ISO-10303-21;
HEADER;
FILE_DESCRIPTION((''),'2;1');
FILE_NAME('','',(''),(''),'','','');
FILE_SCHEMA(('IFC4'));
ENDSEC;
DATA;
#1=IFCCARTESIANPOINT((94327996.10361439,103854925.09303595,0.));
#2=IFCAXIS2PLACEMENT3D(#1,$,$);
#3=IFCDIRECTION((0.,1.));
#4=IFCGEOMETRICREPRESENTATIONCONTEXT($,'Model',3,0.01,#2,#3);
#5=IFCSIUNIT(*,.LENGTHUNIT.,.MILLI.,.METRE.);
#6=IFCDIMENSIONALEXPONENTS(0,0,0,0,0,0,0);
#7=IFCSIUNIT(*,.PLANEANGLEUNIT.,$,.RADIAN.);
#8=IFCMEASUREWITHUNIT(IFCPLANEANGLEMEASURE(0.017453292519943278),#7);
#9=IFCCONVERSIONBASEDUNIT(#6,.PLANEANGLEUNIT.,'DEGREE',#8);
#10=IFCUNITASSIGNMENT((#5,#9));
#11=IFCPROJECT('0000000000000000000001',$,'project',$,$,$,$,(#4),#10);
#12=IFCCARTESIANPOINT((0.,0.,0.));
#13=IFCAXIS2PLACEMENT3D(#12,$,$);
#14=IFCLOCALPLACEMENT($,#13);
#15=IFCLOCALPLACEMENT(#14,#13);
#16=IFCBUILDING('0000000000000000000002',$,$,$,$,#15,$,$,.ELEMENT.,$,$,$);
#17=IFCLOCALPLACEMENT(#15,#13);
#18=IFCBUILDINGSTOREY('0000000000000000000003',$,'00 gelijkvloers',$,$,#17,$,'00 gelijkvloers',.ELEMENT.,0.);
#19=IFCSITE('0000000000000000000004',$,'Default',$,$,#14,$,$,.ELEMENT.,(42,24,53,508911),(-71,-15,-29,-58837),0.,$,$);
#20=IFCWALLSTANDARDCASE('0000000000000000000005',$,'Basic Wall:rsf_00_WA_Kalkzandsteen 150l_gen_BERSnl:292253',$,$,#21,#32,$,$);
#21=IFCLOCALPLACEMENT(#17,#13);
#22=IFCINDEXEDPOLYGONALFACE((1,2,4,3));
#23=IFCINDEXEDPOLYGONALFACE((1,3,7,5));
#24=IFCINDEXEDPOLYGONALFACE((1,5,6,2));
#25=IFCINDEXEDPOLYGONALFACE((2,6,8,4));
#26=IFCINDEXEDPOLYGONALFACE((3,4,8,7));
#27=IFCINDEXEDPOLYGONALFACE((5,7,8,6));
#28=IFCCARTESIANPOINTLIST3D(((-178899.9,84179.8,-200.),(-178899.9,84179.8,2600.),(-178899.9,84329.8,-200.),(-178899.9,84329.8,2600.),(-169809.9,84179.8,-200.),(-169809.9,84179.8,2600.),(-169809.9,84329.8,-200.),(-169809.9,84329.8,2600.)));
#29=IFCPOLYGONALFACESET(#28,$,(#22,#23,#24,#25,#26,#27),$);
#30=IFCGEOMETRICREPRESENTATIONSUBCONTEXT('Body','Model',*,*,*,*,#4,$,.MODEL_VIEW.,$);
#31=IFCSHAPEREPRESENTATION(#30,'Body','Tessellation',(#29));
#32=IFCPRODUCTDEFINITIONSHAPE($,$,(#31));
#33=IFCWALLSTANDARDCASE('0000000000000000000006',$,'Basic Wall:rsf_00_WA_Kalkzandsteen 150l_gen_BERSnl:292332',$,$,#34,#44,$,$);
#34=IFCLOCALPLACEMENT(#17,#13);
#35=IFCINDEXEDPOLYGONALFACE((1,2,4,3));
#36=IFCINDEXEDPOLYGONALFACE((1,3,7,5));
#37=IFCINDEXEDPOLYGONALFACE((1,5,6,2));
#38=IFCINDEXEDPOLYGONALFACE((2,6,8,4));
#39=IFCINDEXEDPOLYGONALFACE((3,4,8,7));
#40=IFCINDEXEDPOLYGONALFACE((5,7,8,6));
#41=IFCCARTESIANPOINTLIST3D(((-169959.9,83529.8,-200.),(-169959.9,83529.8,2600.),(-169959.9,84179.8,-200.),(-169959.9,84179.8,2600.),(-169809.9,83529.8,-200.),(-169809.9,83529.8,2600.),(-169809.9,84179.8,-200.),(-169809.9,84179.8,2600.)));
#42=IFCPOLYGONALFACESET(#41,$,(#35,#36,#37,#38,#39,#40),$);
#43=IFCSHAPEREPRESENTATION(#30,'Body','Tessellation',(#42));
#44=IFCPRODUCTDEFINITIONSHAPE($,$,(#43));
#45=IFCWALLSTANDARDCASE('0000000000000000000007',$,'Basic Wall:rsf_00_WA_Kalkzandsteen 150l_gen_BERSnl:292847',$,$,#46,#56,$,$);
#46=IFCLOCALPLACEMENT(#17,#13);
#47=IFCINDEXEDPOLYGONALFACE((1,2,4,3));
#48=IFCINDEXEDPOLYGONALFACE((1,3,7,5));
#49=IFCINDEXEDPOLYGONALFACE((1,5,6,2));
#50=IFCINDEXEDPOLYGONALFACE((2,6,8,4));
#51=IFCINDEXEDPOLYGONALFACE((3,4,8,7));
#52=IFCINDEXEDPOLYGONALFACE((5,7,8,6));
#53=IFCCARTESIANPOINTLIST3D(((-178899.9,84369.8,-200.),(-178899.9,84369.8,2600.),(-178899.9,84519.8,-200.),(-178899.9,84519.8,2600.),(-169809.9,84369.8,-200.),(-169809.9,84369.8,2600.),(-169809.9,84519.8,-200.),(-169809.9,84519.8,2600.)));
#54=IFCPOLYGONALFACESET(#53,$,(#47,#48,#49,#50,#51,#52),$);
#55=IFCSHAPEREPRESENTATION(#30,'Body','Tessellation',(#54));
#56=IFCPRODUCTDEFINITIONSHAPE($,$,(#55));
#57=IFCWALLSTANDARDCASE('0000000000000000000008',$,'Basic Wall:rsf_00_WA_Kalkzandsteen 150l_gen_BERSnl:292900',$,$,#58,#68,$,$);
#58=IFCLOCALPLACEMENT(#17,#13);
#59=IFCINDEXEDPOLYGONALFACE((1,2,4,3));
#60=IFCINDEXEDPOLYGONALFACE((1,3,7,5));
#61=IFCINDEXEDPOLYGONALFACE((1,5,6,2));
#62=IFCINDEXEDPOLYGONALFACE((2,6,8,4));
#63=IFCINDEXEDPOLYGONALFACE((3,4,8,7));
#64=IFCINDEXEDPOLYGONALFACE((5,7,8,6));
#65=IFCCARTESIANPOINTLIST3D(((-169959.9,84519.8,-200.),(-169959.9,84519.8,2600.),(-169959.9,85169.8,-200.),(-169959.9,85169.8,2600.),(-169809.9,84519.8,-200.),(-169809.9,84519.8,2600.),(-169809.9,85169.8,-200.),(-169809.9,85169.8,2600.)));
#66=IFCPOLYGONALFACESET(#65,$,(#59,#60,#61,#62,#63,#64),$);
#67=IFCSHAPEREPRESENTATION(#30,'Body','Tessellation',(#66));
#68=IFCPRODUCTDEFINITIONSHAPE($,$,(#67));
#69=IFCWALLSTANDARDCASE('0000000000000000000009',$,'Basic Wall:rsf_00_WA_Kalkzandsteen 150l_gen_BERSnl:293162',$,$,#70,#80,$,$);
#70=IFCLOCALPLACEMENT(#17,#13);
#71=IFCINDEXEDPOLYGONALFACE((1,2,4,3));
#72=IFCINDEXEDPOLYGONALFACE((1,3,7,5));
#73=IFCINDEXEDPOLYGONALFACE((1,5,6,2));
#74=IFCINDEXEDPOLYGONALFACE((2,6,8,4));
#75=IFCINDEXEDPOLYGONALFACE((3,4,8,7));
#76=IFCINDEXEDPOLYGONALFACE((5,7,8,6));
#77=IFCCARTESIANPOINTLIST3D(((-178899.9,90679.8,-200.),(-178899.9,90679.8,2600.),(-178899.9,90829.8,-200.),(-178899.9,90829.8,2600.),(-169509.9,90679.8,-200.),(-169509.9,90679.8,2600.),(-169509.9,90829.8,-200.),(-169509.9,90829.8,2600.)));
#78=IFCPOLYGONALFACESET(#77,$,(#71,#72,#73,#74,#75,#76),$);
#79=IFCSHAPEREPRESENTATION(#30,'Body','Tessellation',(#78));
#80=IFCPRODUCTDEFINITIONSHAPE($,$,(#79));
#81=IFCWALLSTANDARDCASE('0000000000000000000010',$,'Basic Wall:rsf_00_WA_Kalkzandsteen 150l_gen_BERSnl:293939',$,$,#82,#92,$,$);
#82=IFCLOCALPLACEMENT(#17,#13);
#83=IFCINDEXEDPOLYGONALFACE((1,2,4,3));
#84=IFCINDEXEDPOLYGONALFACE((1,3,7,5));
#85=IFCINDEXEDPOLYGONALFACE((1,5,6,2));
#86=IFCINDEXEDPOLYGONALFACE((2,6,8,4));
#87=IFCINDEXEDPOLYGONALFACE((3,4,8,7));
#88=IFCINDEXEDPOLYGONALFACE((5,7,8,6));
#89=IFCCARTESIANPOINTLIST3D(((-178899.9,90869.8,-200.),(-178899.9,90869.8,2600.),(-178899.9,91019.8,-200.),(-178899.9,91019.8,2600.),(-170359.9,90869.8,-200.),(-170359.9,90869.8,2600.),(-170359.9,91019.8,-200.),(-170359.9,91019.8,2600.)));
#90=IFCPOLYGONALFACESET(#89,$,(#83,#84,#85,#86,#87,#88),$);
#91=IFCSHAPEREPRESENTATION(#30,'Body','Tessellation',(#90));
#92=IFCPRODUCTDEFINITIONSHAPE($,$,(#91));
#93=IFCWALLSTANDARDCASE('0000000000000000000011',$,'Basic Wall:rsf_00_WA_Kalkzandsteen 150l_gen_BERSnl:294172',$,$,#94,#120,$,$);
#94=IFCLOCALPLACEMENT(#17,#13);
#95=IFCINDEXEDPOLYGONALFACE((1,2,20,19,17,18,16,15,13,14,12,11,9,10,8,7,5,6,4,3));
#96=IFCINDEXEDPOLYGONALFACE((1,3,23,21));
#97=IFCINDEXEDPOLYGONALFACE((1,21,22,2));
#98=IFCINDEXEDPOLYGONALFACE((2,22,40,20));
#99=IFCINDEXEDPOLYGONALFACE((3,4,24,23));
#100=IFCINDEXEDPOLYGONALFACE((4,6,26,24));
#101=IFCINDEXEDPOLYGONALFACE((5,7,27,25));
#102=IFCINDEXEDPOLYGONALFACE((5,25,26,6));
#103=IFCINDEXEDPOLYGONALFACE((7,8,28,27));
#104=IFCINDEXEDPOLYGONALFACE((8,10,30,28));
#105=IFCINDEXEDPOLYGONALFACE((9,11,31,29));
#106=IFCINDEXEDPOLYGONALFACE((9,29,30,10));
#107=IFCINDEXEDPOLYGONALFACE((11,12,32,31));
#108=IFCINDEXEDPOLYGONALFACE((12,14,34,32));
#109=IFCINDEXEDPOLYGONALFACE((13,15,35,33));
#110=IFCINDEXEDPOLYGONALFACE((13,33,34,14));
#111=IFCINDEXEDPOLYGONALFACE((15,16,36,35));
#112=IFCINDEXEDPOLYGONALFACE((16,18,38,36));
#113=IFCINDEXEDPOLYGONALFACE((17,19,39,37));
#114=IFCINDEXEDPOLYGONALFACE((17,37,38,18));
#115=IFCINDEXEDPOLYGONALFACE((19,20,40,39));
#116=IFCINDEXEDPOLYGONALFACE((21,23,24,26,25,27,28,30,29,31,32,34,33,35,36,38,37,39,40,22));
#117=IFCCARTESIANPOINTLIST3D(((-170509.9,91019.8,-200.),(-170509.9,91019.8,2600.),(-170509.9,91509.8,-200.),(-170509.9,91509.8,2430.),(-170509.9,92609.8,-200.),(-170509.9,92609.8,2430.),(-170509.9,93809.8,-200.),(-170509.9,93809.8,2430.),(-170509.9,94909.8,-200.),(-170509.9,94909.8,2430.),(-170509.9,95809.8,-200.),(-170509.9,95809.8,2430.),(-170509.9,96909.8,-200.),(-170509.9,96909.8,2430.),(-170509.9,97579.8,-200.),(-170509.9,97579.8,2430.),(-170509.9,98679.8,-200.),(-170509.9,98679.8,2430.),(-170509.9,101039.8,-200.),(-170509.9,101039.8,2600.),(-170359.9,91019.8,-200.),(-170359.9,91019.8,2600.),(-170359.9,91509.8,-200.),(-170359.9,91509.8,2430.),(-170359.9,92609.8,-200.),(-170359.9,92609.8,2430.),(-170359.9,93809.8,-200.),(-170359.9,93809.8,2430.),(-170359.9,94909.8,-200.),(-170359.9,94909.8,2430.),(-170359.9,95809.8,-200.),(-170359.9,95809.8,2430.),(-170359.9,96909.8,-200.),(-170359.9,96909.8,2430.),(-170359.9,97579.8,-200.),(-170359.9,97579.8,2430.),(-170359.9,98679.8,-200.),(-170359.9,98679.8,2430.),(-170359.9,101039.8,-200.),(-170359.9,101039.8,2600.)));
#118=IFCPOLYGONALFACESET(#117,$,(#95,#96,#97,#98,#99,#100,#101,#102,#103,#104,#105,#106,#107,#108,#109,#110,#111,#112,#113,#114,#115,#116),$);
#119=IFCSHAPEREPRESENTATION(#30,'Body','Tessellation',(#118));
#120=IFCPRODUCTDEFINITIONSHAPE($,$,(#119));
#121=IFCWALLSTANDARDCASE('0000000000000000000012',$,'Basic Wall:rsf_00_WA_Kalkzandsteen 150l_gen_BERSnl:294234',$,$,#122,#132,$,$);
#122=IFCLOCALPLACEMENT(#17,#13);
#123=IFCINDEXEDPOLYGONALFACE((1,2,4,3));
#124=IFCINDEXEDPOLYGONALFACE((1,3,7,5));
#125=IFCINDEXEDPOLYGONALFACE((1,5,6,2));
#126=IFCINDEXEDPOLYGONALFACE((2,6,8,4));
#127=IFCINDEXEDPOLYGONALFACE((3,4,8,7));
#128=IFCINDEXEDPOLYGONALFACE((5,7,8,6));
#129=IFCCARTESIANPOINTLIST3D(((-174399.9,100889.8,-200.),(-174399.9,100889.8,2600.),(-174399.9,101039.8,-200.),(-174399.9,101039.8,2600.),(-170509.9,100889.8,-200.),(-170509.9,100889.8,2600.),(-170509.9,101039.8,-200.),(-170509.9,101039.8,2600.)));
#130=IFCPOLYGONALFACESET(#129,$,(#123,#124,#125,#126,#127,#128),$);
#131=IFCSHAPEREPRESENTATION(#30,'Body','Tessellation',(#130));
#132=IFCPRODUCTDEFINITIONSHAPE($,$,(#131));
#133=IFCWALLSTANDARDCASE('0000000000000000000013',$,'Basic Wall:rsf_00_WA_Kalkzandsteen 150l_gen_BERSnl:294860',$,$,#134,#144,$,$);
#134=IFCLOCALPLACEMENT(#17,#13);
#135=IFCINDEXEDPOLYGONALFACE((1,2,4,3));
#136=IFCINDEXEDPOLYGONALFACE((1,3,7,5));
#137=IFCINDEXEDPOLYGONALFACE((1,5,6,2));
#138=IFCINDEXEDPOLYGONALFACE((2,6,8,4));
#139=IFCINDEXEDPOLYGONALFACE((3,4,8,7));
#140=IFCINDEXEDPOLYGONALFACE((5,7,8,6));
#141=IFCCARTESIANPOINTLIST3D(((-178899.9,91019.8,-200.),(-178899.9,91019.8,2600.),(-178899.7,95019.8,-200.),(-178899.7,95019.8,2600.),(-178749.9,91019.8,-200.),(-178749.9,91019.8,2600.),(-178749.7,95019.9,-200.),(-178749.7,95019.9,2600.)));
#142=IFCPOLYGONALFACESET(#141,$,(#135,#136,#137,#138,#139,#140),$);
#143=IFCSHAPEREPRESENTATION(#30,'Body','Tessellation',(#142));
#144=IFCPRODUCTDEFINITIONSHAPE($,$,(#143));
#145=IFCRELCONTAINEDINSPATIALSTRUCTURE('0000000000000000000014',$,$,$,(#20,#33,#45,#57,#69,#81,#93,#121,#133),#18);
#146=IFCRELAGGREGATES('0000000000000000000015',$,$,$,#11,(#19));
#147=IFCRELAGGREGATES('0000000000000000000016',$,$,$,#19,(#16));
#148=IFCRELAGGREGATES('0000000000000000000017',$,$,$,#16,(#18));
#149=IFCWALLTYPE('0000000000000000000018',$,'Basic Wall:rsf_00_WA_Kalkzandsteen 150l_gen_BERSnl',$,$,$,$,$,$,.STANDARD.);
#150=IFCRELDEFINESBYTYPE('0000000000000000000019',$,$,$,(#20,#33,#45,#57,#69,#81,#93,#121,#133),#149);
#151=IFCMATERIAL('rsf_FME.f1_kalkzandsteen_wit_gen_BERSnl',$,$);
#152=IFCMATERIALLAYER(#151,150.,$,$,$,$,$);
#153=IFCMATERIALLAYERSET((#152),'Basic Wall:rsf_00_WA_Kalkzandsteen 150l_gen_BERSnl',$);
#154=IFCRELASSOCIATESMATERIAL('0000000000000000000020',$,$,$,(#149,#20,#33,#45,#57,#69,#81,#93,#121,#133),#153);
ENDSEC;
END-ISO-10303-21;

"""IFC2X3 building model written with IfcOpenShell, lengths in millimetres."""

from ifc_helpers import new_model, entity, si_unit, converted_unit, direction, frame, frame_2d, origin, origin_2d_with_axis, place, context, subcontext, project, spatial, polyline, rectangle, outline, extrude, clip, bounded_halfspace, material, layer, layer_set, layer_usage, type_object, element, save


model = new_model("IFC2X3")

# Units and contexts
model_context = context("Model", 3, precision=0.01, world=frame((94327996.10361439, 103854925.09303595, 0.0)), true_north=direction((0.0, 1.0)))
body_context = subcontext(model_context, "Body", "Model", "MODEL_VIEW")
ifc_project = project(units=[si_unit("LENGTHUNIT", "METRE", prefix="MILLI"), converted_unit("PLANEANGLEUNIT", "DEGREE", entity("IfcPlaneAngleMeasure", 0.017453292519943278), si_unit("PLANEANGLEUNIT", "RADIAN"), dimensions=[0, 0, 0, 0, 0, 0, 0])], contexts=[model_context])

# Site, building, storey
site_placement = place(None, origin())
site = spatial("IfcSite", under=ifc_project, at=site_placement, Name="Default", CompositionType="ELEMENT", RefLatitude=(42, 24, 53, 508911), RefLongitude=(-71, -15, -29, -58837), RefElevation=0.0)
building_placement = place(site_placement, origin())
building = spatial("IfcBuilding", under=site, at=building_placement, CompositionType="ELEMENT")
storey_placement = place(building_placement, origin())
storey = spatial("IfcBuildingStorey", under=building, at=storey_placement, Name="00 gelijkvloers", LongName="00 gelijkvloers", CompositionType="ELEMENT", Elevation=0.0)

# Walls
ifc_material = material(Name="rsf_FME.f1_kalkzandsteen_wit_gen_BERSnl")
ifc_layer = layer(ifc_material, 150.0)
ifc_layer_set = layer_set([ifc_layer], Name="Basic Wall:rsf_00_WA_Kalkzandsteen 150l_gen_BERSnl")
ifc_layer_usage_1 = layer_usage(ifc_layer_set, "AXIS2", "POSITIVE", -75.0)
wall_type = type_object("IfcWallType", Name="Basic Wall:rsf_00_WA_Kalkzandsteen 150l_gen_BERSnl", PredefinedType="STANDARD", material=ifc_layer_set)
wall_1_placement = place(storey_placement, frame((-178899.9, 84254.8, -200.0)))
element("IfcWallStandardCase", 1, at=wall_1_placement, inside=storey, type_object=wall_type, material=ifc_layer_usage_1, Name="Basic Wall:rsf_00_WA_Kalkzandsteen 150l_gen_BERSnl:292253", context=body_context, shape_type="Clipping", body=[
    clip(extrude(rectangle(XDim=9090.0, YDim=150.0, at=frame_2d((4545.0, 0.0), x_axis=(-1.0, 0.0))), origin(), (0.0, 0.0, 1.0), 2800.0), bounded_halfspace(frame((0.0, 75.0, 2800.0), z_axis=(0.0, 0.0, -1.0), x_axis=(0.0, 1.0, 0.0)), True, frame((0.0, 75.0, 2800.0)), polyline([(0.0, 0.0), (0.0, -150.0), (150.0, -150.0), (8940.0, -150.0), (9090.0, -150.0), (9090.0, 0.0), (0.0, 0.0)]))),
])
ifc_layer_usage_2 = layer_usage(ifc_layer_set, "AXIS2", "POSITIVE", -75.0)
wall_2_placement = place(storey_placement, frame((-169884.9, 84179.8, -200.0), z_axis=(0.0, 0.0, 1.0), x_axis=(0.0, -1.0, 0.0)))
element("IfcWallStandardCase", 2, at=wall_2_placement, inside=storey, type_object=wall_type, material=ifc_layer_usage_2, Name="Basic Wall:rsf_00_WA_Kalkzandsteen 150l_gen_BERSnl:292332", context=body_context, shape_type="Clipping", body=[
    clip(extrude(rectangle(XDim=650.0, YDim=150.0, at=frame_2d((325.0, 0.0), x_axis=(-1.0, 0.0))), origin(), (0.0, 0.0, 1.0), 2800.0), bounded_halfspace(frame((0.0, -75.0, 2800.0), z_axis=(0.0, 0.0, -1.0), x_axis=(-1.0, 0.0, 0.0)), True, frame((0.0, -75.0, 2800.0)), polyline([(0.0, 0.0), (650.0, 0.0), (650.0, 150.0), (500.0, 150.0), (0.0, 150.0), (0.0, 0.0)]))),
])
ifc_layer_usage_3 = layer_usage(ifc_layer_set, "AXIS2", "NEGATIVE", 75.0)
wall_3_placement = place(storey_placement, frame((-178899.9, 84444.8, -200.0)))
element("IfcWallStandardCase", 3, at=wall_3_placement, inside=storey, type_object=wall_type, material=ifc_layer_usage_3, Name="Basic Wall:rsf_00_WA_Kalkzandsteen 150l_gen_BERSnl:292847", context=body_context, shape_type="Clipping", body=[
    clip(extrude(rectangle(XDim=9090.0, YDim=150.0, at=frame_2d((4545.0, 0.0), x_axis=(-1.0, 0.0))), origin(), (0.0, 0.0, 1.0), 2800.0), bounded_halfspace(frame((0.0, 75.0, 2800.0), z_axis=(0.0, 0.0, -1.0), x_axis=(0.0, 1.0, 0.0)), True, frame((0.0, 75.0, 2800.0)), polyline([(0.0, 0.0), (0.0, -150.0), (9090.0, -150.0), (9090.0, 0.0), (8940.0, 0.0), (150.0, 0.0), (0.0, 0.0)]))),
])
ifc_layer_usage_4 = layer_usage(ifc_layer_set, "AXIS2", "NEGATIVE", 75.0)
wall_4_placement = place(storey_placement, frame((-169884.9, 84519.8, -200.0), z_axis=(0.0, 0.0, 1.0), x_axis=(0.0, 1.0, 0.0)))
element("IfcWallStandardCase", 4, at=wall_4_placement, inside=storey, type_object=wall_type, material=ifc_layer_usage_4, Name="Basic Wall:rsf_00_WA_Kalkzandsteen 150l_gen_BERSnl:292900", context=body_context, shape_type="Clipping", body=[
    clip(extrude(rectangle(XDim=650.0, YDim=150.0, at=frame_2d((325.0, 0.0), x_axis=(-1.0, 0.0))), origin(), (0.0, 0.0, 1.0), 2800.0), bounded_halfspace(frame((0.0, -75.0, 2800.0), z_axis=(0.0, 0.0, -1.0), x_axis=(1.0, 0.0, 0.0)), True, frame((0.0, -75.0, 2800.0)), polyline([(0.0, 0.0), (500.0, 0.0), (650.0, 0.0), (650.0, 150.0), (0.0, 150.0), (0.0, 0.0)]))),
])

# Walls
ifc_layer_usage_5 = layer_usage(ifc_layer_set, "AXIS2", "NEGATIVE", 75.0)
wall_5_placement = place(storey_placement, frame((-169509.9, 90754.8, -200.0), z_axis=(0.0, 0.0, 1.0), x_axis=(-1.0, 0.0, 0.0)))
element("IfcWallStandardCase", 5, at=wall_5_placement, inside=storey, type_object=wall_type, material=ifc_layer_usage_5, Name="Basic Wall:rsf_00_WA_Kalkzandsteen 150l_gen_BERSnl:293162", context=body_context, shape_type="Clipping", body=[
    clip(clip(extrude(rectangle(XDim=9390.0, YDim=150.0, at=frame_2d((4695.0, 0.0), x_axis=(-1.0, 0.0))), origin(), (0.0, 0.0, 1.0), 2800.0), bounded_halfspace(frame((9390.0, -75.0, 0.0), z_axis=(0.0, 0.0, 1.0), x_axis=(-1.0, 0.0, 0.0)), True, frame((9390.0, -75.0, 0.0)), polyline([(0.0, 0.0), (0.0, 150.0), (-150.0, 150.0), (-9390.0, 150.0), (-9390.0, 0.0), (0.0, 0.0)]))), bounded_halfspace(frame((0.0, -75.0, 2800.0), z_axis=(0.0, 0.0, -1.0), x_axis=(0.0, -1.0, 0.0)), True, frame((0.0, -75.0, 2800.0)), polyline([(0.0, 0.0), (850.0, 0.0), (9390.0, 0.0), (9390.0, 150.0), (9240.0, 150.0), (0.0, 150.0), (0.0, 0.0)]))),
])
ifc_layer_usage_6 = layer_usage(ifc_layer_set, "AXIS2", "NEGATIVE", 75.0)
wall_6_placement = place(storey_placement, frame((-178899.9, 90944.8, -200.0)))
element("IfcWallStandardCase", 6, at=wall_6_placement, inside=storey, type_object=wall_type, material=ifc_layer_usage_6, Name="Basic Wall:rsf_00_WA_Kalkzandsteen 150l_gen_BERSnl:293939", context=body_context, shape_type="Clipping", body=[
    clip(extrude(rectangle(XDim=8540.0, YDim=150.0, at=frame_2d((4270.0, 0.0), x_axis=(-1.0, 0.0))), origin(), (0.0, 0.0, 1.0), 2800.0), bounded_halfspace(frame((0.0, 75.0, 2800.0), z_axis=(0.0, 0.0, -1.0), x_axis=(0.0, 1.0, 0.0)), True, frame((0.0, 75.0, 2800.0)), polyline([(0.0, 0.0), (0.0, -150.0), (8540.0, -150.0), (8540.0, 0.0), (8390.0, 0.0), (4650.0, 0.0), (4500.0, 0.0), (150.0, 0.0), (0.0, 0.0)]))),
])

# Wall, openings
ifc_layer_usage_7 = layer_usage(ifc_layer_set, "AXIS2", "POSITIVE", -75.0)
wall_7_placement = place(storey_placement, frame((-170434.9, 91019.8, -200.0), z_axis=(0.0, 0.0, 1.0), x_axis=(0.0, 1.0, 0.0)))
wall_7 = element("IfcWallStandardCase", 7, at=wall_7_placement, inside=storey, type_object=wall_type, material=ifc_layer_usage_7, Name="Basic Wall:rsf_00_WA_Kalkzandsteen 150l_gen_BERSnl:294172", context=body_context, shape_type="Clipping", body=[
    clip(extrude(rectangle(XDim=10020.0, YDim=150.0, at=frame_2d((5010.0, 0.0), x_axis=(1.0, 0.0))), origin(), (0.0, 0.0, 1.0), 2800.0), bounded_halfspace(frame((0.0, -75.0, 2800.0), z_axis=(0.0, 0.0, -1.0), x_axis=(1.0, 0.0, 0.0)), True, frame((0.0, -75.0, 2800.0)), polyline([(0.0, 0.0), (10020.0, 0.0), (10020.0, 150.0), (9870.0, 150.0), (2100.0, 150.0), (1950.0, 150.0), (0.0, 150.0), (0.0, 0.0)]))),
])
opening_1_placement = place(wall_7_placement, frame((-91019.8, -170434.9, 200.0), z_axis=(0.0, 0.0, 1.0), x_axis=(0.0, -1.0, 0.0)))
element("IfcOpeningElement", 8, at=opening_1_placement, cuts=wall_7, ObjectType="Opening", context=body_context, shape_type="SweptSolid", body=[
    extrude(rectangle(XDim=2630.0, YDim=1100.0, at=frame_2d((0.0, 0.0), x_axis=(0.0, 1.0))), frame((-168835.9, 92059.8, 1115.0), z_axis=(-1.0, 0.0, 0.0), x_axis=(0.0, -1.0, 0.0)), (0.0, 0.0, 1.0), 3048.0),
])
opening_2_placement = place(wall_7_placement, frame((-91019.8, -170434.9, 200.0), z_axis=(0.0, 0.0, 1.0), x_axis=(0.0, -1.0, 0.0)))
element("IfcOpeningElement", 9, at=opening_2_placement, cuts=wall_7, ObjectType="Opening", context=body_context, shape_type="SweptSolid", body=[
    extrude(rectangle(XDim=2630.0, YDim=1100.0, at=origin_2d_with_axis()), frame((-168985.9, 94359.8, 1115.0), z_axis=(-1.0, 0.0, 0.0), x_axis=(0.0, 0.0, 1.0)), (0.0, 0.0, 1.0), 3048.0),
])
opening_3_placement = place(wall_7_placement, frame((-91019.8, -170434.9, 200.0), z_axis=(0.0, 0.0, 1.0), x_axis=(0.0, -1.0, 0.0)))
element("IfcOpeningElement", 10, at=opening_3_placement, cuts=wall_7, ObjectType="Opening", context=body_context, shape_type="SweptSolid", body=[
    extrude(rectangle(XDim=2630.0, YDim=1100.0, at=origin_2d_with_axis()), frame((-168985.9, 96359.8, 1115.0), z_axis=(-1.0, 0.0, 0.0), x_axis=(0.0, 0.0, 1.0)), (0.0, 0.0, 1.0), 3048.0),
])
opening_4_placement = place(wall_7_placement, frame((-91019.8, -170434.9, 200.0), z_axis=(0.0, 0.0, 1.0), x_axis=(0.0, -1.0, 0.0)))
element("IfcOpeningElement", 11, at=opening_4_placement, cuts=wall_7, ObjectType="Opening", context=body_context, shape_type="SweptSolid", body=[
    extrude(rectangle(XDim=2630.0, YDim=1100.0, at=origin_2d_with_axis()), frame((-168985.9, 98129.8, 1115.0), z_axis=(-1.0, 0.0, 0.0), x_axis=(0.0, 0.0, 1.0)), (0.0, 0.0, 1.0), 3048.0),
])

# Walls
ifc_layer_usage_8 = layer_usage(ifc_layer_set, "AXIS2", "POSITIVE", -75.0)
wall_8_placement = place(storey_placement, frame((-170509.9, 100964.8, -200.0), z_axis=(0.0, 0.0, 1.0), x_axis=(-1.0, 0.0, 0.0)))
element("IfcWallStandardCase", 12, at=wall_8_placement, inside=storey, type_object=wall_type, material=ifc_layer_usage_8, Name="Basic Wall:rsf_00_WA_Kalkzandsteen 150l_gen_BERSnl:294234", context=body_context, shape_type="Clipping", body=[
    clip(extrude(rectangle(XDim=3890.0, YDim=150.0, at=frame_2d((1945.0, 0.0), x_axis=(-1.0, 0.0))), origin(), (0.0, 0.0, 1.0), 2800.0), bounded_halfspace(frame((0.0, -75.0, 2800.0), z_axis=(0.0, 0.0, -1.0), x_axis=(0.0, -1.0, 0.0)), True, frame((0.0, -75.0, 2800.0)), polyline([(0.0, 0.0), (3890.0, 0.0), (3890.0, 150.0), (3740.0, 150.0), (0.0, 150.0), (0.0, 0.0)]))),
])
ifc_layer_usage_9 = layer_usage(ifc_layer_set, "AXIS2", "POSITIVE", -75.0)
wall_9_placement = place(storey_placement, frame((-178824.7, 95020.0, -200.0), z_axis=(0.0, 0.0, 1.0), x_axis=(-0.00004, -1.0, 0.0)))
element("IfcWallStandardCase", 13, at=wall_9_placement, inside=storey, type_object=wall_type, material=ifc_layer_usage_9, Name="Basic Wall:rsf_00_WA_Kalkzandsteen 150l_gen_BERSnl:294860", context=body_context, shape_type="Clipping", body=[
    clip(extrude(outline(polyline([(4000.2, -75.0), (4000.2, 75.0), (0.0, 75.0), (0.2, -75.0), (4000.2, -75.0)])), origin(), (0.0, 0.0, 1.0), 2800.0), bounded_halfspace(frame((0.2, -75.0, 2800.0), z_axis=(0.0, 0.0, -1.0), x_axis=(-1.0, -0.00004, 0.0)), True, frame((0.2, -75.0, 2800.0)), polyline([(0.0, 0.0), (4000.0, 0.0), (4000.0, 150.0), (-0.2, 150.0), (0.0, 0.0)]))),
])

save(model, "model.ifc")
